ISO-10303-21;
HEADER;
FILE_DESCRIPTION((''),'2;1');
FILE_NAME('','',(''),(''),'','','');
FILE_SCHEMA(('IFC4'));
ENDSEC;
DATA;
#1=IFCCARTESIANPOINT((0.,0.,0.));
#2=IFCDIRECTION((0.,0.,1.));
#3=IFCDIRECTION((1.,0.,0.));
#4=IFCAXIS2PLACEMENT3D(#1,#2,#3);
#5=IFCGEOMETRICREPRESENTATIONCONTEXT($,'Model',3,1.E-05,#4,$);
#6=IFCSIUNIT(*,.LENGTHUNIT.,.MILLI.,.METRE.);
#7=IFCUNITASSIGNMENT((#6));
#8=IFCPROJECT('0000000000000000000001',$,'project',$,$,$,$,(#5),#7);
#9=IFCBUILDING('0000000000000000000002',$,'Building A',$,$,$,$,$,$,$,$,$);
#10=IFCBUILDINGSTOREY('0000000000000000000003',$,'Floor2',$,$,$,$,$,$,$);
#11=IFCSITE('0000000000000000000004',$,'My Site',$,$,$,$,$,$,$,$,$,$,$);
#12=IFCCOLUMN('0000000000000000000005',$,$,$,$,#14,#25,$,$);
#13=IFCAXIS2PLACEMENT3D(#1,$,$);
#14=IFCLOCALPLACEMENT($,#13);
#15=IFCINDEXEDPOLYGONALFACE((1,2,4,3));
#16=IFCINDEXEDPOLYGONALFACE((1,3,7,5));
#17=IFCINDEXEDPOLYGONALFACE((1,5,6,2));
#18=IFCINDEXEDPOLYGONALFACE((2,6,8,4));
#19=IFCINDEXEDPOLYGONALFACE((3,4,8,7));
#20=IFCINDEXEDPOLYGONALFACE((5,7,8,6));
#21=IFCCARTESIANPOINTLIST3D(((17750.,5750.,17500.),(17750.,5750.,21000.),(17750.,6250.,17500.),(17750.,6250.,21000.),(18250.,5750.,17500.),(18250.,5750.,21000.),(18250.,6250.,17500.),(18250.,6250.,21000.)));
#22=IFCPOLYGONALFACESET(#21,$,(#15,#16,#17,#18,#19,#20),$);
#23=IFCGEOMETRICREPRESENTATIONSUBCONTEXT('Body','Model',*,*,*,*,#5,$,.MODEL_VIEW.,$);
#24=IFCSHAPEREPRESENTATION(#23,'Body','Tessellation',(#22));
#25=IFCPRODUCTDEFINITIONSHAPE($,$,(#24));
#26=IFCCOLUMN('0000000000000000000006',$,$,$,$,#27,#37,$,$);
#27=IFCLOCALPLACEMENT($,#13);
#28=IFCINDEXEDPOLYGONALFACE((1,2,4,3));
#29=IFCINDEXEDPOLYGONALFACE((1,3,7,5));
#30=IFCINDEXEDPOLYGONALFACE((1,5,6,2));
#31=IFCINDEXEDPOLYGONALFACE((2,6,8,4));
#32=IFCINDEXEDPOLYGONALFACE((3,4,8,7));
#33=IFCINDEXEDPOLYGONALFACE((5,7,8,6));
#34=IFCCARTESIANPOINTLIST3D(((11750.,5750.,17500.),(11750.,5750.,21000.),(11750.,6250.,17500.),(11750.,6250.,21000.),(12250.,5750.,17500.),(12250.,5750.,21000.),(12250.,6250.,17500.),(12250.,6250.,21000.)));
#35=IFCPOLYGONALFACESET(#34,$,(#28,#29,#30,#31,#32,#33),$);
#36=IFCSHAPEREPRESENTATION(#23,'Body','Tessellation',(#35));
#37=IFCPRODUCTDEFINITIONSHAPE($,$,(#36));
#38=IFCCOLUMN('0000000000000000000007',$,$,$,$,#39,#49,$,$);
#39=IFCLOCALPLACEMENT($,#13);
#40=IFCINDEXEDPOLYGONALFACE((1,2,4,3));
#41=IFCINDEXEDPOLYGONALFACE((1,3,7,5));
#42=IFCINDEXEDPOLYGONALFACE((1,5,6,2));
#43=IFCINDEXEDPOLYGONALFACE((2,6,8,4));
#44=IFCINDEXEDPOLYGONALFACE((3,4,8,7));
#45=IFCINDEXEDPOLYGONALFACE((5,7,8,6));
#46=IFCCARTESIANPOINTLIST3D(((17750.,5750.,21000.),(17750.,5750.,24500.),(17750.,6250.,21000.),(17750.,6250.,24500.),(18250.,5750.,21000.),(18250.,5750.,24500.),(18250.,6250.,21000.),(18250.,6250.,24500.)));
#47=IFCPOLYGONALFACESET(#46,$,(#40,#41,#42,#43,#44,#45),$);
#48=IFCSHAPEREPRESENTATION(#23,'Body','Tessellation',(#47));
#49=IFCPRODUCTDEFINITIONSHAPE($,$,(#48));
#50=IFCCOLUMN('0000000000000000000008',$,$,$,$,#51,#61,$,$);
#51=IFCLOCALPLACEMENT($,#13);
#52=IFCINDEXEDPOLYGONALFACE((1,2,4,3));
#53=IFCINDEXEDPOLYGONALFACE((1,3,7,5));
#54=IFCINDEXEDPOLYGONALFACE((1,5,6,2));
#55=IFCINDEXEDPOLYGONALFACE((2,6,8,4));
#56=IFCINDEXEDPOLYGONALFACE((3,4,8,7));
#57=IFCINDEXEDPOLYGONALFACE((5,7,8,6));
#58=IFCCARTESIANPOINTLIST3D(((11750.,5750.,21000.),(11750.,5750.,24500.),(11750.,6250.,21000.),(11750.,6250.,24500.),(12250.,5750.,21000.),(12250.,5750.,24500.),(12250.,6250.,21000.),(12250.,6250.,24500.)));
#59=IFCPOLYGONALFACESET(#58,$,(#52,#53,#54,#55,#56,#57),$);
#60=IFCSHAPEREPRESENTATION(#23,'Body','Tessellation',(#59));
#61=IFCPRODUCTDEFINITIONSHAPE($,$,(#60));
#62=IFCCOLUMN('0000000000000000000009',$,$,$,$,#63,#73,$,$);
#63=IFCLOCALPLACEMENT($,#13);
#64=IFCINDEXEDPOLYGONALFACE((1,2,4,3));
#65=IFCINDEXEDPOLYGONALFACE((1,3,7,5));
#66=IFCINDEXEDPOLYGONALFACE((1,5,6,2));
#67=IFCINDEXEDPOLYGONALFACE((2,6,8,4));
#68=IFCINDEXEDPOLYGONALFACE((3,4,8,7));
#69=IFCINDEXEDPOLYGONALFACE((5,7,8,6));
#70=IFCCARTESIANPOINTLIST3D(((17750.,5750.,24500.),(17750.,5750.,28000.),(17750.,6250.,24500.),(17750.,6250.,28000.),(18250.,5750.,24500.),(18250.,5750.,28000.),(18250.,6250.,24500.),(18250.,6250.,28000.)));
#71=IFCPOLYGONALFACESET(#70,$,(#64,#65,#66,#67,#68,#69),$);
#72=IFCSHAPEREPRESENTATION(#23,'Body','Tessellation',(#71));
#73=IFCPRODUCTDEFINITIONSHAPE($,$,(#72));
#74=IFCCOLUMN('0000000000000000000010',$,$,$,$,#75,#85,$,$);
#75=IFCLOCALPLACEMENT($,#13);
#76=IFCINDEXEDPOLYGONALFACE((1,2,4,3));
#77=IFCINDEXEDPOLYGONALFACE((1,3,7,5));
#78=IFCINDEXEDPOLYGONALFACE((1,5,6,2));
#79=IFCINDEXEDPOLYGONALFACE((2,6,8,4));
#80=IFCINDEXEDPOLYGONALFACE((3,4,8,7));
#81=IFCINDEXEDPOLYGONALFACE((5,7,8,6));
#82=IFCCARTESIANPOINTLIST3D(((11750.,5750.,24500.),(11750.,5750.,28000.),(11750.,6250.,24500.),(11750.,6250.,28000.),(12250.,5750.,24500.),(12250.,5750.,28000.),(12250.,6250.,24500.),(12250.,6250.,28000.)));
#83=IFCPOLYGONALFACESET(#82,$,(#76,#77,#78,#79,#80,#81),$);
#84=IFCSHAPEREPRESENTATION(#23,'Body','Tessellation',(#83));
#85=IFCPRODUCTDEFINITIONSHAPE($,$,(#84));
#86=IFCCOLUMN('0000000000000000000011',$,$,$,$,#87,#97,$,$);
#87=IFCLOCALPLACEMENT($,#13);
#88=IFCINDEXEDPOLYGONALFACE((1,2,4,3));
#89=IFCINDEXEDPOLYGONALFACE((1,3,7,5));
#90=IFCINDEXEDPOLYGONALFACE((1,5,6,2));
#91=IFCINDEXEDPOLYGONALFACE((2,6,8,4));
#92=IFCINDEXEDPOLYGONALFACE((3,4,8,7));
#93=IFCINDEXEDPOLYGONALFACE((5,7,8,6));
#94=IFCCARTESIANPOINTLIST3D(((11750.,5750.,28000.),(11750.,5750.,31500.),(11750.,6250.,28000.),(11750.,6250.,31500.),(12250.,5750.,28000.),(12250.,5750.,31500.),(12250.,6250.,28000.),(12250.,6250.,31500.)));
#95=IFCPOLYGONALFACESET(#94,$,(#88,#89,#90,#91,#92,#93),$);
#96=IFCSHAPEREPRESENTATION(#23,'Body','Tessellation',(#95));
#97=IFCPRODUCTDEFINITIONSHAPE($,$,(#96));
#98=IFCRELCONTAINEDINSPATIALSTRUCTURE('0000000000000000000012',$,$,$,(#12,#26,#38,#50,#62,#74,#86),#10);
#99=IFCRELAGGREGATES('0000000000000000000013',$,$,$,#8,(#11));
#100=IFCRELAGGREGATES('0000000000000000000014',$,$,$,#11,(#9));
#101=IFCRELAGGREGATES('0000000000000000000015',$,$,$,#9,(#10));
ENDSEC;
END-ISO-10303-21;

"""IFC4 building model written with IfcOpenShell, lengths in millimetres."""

from ifc_helpers import new_model, si_unit, frame, origin_with_axes, place, context, subcontext, project, spatial, line, indexed_curve, outline, extrude, element, save


model = new_model("IFC4")

# Units and contexts
model_context = context("Model", 3, precision=1e-05, world=origin_with_axes())
body_context = subcontext(model_context, "Body", "Model", "MODEL_VIEW")
ifc_project = project(units=[si_unit("LENGTHUNIT", "METRE", prefix="MILLI")], contexts=[model_context])

# Site, building, storey
site = spatial("IfcSite", under=ifc_project, Name="My Site")
building = spatial("IfcBuilding", under=site, Name="Building A")
storey = spatial("IfcBuildingStorey", under=building, Name="Floor2")

# Columns
for number, where, z_axis, x_axis in (
    (1, (18000.0, 6000.0, 17500.0), (0.0, 0.0, 1.0), (1.0, 0.0, 0.0)),
    (2, (12000.0, 6000.0, 17500.0), (0.0, 0.0, 1.0), (1.0, 0.0, 0.0)),
    (3, (18000.0, 6000.0, 21000.0), (0.0, 0.0, 1.0), (1.0, 0.0, 0.0)),
    (4, (12000.0, 6000.0, 21000.0), (0.0, 0.0, 1.0), (1.0, 0.0, 0.0)),
    (5, (18000.0, 6000.0, 24500.0), (0.0, 0.0, 1.0), (1.0, 0.0, 0.0)),
    (6, (12000.0, 6000.0, 24500.0), (0.0, 0.0, 1.0), (1.0, 0.0, 0.0)),
    (7, (12000.0, 6000.0, 28000.0), (0.0, 0.0, 1.0), (1.0, 0.0, 0.0)),
):
    element("IfcColumn", number, at=place(None, frame(where, z_axis=z_axis, x_axis=x_axis)), inside=storey, context=body_context, shape_type="SweptSolid", body=[
        extrude(outline(indexed_curve([(-250.0, -250.0), (250.0, -250.0), (250.0, 250.0), (-250.0, 250.0)], segments=[line(1, 2, 3, 4, 1)])), origin_with_axes(), (0.0, 0.0, 1.0), 3500.0),
    ])

save(model, "model.ifc")
